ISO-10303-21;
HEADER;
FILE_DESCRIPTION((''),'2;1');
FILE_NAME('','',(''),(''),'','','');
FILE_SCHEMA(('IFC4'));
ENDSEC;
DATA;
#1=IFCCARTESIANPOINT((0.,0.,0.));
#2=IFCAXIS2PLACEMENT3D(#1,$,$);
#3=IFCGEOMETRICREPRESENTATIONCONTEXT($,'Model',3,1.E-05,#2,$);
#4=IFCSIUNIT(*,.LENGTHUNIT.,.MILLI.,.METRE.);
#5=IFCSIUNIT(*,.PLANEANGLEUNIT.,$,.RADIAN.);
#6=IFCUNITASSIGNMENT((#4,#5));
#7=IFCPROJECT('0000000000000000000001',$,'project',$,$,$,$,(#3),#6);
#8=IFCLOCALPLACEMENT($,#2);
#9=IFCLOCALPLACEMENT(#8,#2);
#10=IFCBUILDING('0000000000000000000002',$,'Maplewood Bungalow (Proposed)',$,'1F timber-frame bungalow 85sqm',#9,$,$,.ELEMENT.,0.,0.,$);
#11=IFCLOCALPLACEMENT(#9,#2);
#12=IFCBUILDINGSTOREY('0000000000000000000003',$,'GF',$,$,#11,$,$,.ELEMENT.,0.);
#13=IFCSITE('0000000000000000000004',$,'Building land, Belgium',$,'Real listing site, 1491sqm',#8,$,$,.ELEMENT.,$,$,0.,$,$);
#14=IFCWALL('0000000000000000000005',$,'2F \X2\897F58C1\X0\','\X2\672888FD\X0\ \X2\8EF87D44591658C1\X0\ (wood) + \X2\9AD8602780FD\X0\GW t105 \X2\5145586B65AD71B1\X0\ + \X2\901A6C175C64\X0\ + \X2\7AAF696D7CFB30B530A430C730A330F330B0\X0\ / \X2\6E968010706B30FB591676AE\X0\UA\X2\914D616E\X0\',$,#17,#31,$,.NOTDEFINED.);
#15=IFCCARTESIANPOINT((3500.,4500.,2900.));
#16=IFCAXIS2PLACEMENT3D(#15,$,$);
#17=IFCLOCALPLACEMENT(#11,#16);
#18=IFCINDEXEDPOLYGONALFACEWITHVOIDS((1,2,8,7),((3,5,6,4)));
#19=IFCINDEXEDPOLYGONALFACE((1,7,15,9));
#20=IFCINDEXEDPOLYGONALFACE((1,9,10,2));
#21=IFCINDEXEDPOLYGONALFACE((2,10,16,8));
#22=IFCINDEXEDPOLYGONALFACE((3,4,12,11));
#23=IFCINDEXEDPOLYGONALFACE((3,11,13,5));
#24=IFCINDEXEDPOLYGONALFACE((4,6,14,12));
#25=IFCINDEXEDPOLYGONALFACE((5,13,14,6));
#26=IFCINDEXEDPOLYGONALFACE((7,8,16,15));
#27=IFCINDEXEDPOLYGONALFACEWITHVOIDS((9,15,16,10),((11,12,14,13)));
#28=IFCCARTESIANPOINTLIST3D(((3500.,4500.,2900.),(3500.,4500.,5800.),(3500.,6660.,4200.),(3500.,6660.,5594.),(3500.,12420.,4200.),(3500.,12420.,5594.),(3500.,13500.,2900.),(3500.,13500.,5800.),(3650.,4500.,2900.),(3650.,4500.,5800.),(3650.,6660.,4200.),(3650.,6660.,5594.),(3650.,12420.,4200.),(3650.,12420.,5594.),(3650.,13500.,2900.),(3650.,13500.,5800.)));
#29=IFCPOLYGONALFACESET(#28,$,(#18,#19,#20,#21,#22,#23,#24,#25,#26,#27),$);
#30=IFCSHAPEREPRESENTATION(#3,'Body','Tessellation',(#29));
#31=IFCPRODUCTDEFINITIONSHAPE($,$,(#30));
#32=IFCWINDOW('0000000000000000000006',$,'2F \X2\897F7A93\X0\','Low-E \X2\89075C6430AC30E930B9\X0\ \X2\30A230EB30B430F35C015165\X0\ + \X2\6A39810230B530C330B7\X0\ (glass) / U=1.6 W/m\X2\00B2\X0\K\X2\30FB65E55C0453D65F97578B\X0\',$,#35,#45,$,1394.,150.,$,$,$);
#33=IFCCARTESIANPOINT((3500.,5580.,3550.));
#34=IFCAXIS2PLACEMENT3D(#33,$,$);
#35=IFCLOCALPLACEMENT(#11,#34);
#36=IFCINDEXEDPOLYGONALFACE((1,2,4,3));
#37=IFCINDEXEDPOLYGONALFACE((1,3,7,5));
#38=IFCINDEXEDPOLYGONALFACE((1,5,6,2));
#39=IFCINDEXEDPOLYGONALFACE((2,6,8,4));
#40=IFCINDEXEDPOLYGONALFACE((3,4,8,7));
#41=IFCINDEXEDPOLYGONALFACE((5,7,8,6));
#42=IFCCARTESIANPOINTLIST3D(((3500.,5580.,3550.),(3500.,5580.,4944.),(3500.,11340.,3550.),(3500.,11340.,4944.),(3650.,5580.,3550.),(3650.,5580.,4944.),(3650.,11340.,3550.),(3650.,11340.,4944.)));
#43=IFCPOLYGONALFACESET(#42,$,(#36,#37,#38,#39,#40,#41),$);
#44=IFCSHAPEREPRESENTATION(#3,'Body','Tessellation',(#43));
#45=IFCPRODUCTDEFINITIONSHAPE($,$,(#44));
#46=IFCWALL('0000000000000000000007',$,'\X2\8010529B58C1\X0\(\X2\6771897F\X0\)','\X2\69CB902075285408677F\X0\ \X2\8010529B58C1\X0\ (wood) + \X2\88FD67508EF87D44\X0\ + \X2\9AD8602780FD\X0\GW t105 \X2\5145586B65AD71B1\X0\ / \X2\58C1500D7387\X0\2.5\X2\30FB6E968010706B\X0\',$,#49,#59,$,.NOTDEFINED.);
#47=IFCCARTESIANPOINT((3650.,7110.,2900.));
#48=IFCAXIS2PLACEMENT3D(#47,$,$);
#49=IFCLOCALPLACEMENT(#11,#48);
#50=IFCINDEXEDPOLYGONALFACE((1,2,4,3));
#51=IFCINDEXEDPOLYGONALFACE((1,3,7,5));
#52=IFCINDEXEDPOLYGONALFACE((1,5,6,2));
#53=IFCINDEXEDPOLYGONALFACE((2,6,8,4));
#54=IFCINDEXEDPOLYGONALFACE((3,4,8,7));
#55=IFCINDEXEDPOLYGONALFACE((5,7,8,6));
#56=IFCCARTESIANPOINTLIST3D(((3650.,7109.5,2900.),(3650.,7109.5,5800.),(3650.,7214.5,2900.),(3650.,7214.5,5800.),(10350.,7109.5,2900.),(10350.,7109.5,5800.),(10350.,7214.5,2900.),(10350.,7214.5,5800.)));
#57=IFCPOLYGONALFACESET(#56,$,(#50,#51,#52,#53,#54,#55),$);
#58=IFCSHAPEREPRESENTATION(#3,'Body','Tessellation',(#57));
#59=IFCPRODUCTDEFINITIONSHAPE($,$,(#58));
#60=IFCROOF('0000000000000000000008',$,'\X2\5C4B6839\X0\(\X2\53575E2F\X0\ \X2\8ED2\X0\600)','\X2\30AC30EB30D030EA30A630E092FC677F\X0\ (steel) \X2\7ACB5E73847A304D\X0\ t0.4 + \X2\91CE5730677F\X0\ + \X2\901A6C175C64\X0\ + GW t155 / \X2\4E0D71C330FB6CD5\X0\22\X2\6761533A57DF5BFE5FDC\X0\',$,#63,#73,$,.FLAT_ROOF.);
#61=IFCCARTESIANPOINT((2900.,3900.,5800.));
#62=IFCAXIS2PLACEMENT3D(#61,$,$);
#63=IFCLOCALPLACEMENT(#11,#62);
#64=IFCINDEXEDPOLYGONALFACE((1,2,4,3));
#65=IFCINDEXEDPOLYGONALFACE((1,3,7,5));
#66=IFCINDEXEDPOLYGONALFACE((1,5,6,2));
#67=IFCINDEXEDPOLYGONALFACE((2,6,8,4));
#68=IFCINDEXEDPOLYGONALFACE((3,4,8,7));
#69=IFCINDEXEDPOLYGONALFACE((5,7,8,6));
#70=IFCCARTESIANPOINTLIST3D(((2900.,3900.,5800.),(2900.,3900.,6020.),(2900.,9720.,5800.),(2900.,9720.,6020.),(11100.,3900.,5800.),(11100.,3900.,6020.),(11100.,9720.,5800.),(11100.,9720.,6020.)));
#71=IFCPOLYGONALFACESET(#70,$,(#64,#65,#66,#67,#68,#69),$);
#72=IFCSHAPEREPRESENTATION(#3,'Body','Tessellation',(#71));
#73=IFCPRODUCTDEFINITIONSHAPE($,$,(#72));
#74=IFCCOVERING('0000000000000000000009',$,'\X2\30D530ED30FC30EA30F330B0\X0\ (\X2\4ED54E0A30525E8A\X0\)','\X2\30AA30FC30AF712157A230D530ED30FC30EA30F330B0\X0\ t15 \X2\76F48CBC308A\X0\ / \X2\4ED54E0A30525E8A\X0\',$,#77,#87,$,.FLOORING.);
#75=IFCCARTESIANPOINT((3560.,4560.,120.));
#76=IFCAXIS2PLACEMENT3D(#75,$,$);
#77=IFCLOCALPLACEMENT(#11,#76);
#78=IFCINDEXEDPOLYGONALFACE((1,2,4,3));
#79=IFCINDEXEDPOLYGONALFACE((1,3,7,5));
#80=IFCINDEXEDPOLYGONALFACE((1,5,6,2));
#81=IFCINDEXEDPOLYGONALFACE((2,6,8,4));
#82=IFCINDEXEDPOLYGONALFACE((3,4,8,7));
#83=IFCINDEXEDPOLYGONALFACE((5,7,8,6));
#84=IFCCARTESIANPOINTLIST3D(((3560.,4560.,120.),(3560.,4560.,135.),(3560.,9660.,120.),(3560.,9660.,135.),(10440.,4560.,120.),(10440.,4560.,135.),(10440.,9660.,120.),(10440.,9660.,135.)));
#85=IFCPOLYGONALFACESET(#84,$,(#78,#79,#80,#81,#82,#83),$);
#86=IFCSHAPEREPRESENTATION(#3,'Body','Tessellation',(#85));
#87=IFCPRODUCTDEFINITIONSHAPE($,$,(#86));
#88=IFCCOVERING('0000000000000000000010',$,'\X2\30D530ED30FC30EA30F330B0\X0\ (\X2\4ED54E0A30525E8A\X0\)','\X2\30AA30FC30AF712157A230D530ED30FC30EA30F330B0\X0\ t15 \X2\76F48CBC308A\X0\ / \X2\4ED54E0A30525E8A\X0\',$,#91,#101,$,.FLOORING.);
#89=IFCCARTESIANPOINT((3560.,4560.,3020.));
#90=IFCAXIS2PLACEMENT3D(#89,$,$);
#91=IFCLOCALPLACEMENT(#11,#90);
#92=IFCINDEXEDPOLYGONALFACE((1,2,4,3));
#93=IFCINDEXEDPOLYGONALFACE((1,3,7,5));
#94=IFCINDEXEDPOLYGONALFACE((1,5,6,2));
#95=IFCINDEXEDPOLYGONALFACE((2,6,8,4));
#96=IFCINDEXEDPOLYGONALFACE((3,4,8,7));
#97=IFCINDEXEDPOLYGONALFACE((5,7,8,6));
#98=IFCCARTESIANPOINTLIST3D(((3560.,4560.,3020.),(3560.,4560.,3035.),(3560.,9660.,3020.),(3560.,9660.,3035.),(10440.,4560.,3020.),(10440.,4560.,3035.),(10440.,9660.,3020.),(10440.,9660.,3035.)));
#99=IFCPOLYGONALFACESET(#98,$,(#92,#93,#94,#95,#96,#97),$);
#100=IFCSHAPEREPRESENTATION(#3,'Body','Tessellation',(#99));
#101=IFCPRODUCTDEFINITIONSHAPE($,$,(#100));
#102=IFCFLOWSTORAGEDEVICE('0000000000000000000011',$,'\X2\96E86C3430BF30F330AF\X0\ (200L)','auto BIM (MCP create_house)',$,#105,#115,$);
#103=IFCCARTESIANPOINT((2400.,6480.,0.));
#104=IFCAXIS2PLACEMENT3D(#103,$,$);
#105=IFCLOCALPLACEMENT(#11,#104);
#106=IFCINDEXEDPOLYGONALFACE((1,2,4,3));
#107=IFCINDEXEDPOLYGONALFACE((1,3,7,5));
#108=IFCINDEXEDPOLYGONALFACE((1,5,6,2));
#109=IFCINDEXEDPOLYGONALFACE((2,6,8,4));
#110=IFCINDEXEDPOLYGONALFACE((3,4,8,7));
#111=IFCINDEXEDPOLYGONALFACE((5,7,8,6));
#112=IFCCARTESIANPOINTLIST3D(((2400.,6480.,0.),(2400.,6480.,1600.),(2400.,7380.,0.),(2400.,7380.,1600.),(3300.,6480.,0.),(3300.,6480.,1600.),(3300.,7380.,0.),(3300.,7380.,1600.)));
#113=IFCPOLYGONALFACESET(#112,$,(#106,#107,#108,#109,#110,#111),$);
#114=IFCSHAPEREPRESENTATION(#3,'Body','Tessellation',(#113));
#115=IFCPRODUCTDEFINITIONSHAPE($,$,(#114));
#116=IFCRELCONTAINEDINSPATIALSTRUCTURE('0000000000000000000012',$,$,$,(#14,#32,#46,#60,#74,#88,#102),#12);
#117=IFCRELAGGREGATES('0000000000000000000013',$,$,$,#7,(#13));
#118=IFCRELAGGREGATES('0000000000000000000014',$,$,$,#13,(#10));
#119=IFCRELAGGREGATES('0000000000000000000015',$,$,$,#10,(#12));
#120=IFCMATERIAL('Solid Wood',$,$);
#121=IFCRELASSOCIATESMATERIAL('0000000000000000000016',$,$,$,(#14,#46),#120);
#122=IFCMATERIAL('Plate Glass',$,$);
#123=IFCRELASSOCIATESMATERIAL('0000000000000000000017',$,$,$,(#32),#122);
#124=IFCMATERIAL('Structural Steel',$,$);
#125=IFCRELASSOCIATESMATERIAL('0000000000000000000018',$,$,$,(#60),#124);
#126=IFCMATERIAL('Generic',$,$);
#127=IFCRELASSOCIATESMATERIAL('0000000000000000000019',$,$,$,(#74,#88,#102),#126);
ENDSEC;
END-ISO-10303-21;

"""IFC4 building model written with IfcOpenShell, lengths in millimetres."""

from ifc_helpers import new_model, si_unit, frame, frame_2d, origin, place, context, project, spatial, rectangle, extrude, material, element, fill, save


model = new_model("IFC4")

# Units and contexts
model_context = context("Model", 3, precision=1e-05, world=origin())
ifc_project = project(units=[si_unit("LENGTHUNIT", "METRE", prefix="MILLI"), si_unit("PLANEANGLEUNIT", "RADIAN")], contexts=[model_context])

# Site, building, storey
site_placement = place(None, origin())
site = spatial("IfcSite", under=ifc_project, at=site_placement, Name="Building land, Belgium", ObjectType="Real listing site, 1491sqm", CompositionType="ELEMENT", RefElevation=0.0)
building_placement = place(site_placement, origin())
building = spatial("IfcBuilding", under=site, at=building_placement, Name="Maplewood Bungalow (Proposed)", ObjectType="1F timber-frame bungalow 85sqm", CompositionType="ELEMENT", ElevationOfRefHeight=0.0, ElevationOfTerrain=0.0)
storey_placement = place(building_placement, origin())
storey = spatial("IfcBuildingStorey", under=building, at=storey_placement, Name="GF", CompositionType="ELEMENT", Elevation=0.0)

# Shared definitions
ifc_material_1 = material(Name="Solid Wood")
ifc_material_2 = material(Name="Generic")

# Shared definitions
ifc_material_3 = material(Name="Plate Glass")

# Wall, opening, window
wall_1_placement = place(storey_placement, frame((3500.0, 4500.0, 2900.0)))
wall_1 = element("IfcWall", 1, at=wall_1_placement, inside=storey, material=ifc_material_1, Name="2F 西壁", Description="木製 軸組外壁 (wood) + 高性能GW t105 充填断熱 + 通気層 + 窯業系サイディング / 準耐火・外皮UA配慮", PredefinedType="NOTDEFINED", context=model_context, shape_type="SweptSolid", body=[
    extrude(rectangle(XDim=150.0, YDim=9000.0, at=frame_2d((75.0, 4500.0))), frame((3500.0, 4500.0, 2900.0)), (0.0, 0.0, 1.0), 2900.0),
])
opening_1_placement = place(storey_placement, frame((3500.0, 5580.0, 3550.0)))
opening_1 = element("IfcOpeningElement", 2, at=opening_1_placement, cuts=wall_1, PredefinedType="NOTDEFINED", context=model_context, shape_type="SweptSolid", body=[
    extrude(rectangle(XDim=150.0, YDim=5760.0, at=frame_2d((75.0, 2880.0))), frame((3500.0, 5580.0, 3550.0)), (0.0, 0.0, 1.0), 1394.0),
])
window_1_placement = place(storey_placement, frame((3500.0, 5580.0, 3550.0)))
window_1 = element("IfcWindow", 3, at=window_1_placement, inside=storey, material=ifc_material_3, Name="2F 西窓", Description="Low-E 複層ガラス アルゴン封入 + 樹脂サッシ (glass) / U=1.6 W/m²K・日射取得型", OverallHeight=1394.0, OverallWidth=150.0, context=model_context, shape_type="SweptSolid", body=[
    extrude(rectangle(XDim=150.0, YDim=5760.0, at=frame_2d((75.0, 2880.0))), frame((3500.0, 5580.0, 3550.0)), (0.0, 0.0, 1.0), 1394.0),
])
fill(opening_1, window_1)

# Wall
wall_2_placement = place(storey_placement, frame((3650.0, 7110.0, 2900.0)))
element("IfcWall", 4, at=wall_2_placement, inside=storey, material=ifc_material_1, Name="耐力壁(東西)", Description="構造用合板 耐力壁 (wood) + 製材軸組 + 高性能GW t105 充填断熱 / 壁倍率2.5・準耐火", PredefinedType="NOTDEFINED", context=model_context, shape_type="SweptSolid", body=[
    extrude(rectangle(XDim=6700.0, YDim=105.0, at=frame_2d((3350.0, 52.0))), frame((3650.0, 7110.0, 2900.0)), (0.0, 0.0, 1.0), 2900.0),
])

# Roof
ifc_material_4 = material(Name="Structural Steel")
for number, where, name in (
    (5, (2900.0, 3900.0, 5800.0), "屋根(南帯 軒600)"),
):
    element("IfcRoof", number, at=place(storey_placement, frame(where)), inside=storey, material=ifc_material_4, Name=name, Description="ガルバリウム鋼板 (steel) 立平葺き t0.4 + 野地板 + 通気層 + GW t155 / 不燃・法22条区域対応", PredefinedType="FLAT_ROOF", context=model_context, shape_type="SweptSolid", body=[
        extrude(rectangle(XDim=8200.0, YDim=5820.0, at=frame_2d((4100.0, 2910.0))), frame((2900.0, 3900.0, 5800.0)), (0.0, 0.0, 1.0), 220.0),
    ])

# Coverings
covering_1_placement = place(storey_placement, frame((3560.0, 4560.0, 120.0)))
element("IfcCovering", 6, at=covering_1_placement, inside=storey, material=ifc_material_2, Name="フローリング (仕上げ床)", Description="オーク無垢フローリング t15 直貼り / 仕上げ床", PredefinedType="FLOORING", context=model_context, shape_type="SweptSolid", body=[
    extrude(rectangle(XDim=6880.0, YDim=5100.0, at=frame_2d((3440.0, 2550.0))), frame((3560.0, 4560.0, 120.0)), (0.0, 0.0, 1.0), 15.0),
])
covering_2_placement = place(storey_placement, frame((3560.0, 4560.0, 3020.0)))
element("IfcCovering", 7, at=covering_2_placement, inside=storey, material=ifc_material_2, Name="フローリング (仕上げ床)", Description="オーク無垢フローリング t15 直貼り / 仕上げ床", PredefinedType="FLOORING", context=model_context, shape_type="SweptSolid", body=[
    extrude(rectangle(XDim=6880.0, YDim=5100.0, at=frame_2d((3440.0, 2550.0))), frame((3560.0, 4560.0, 3020.0)), (0.0, 0.0, 1.0), 15.0),
])

# Flow storage device
flow_storage_device_placement = place(storey_placement, frame((2400.0, 6480.0, 0.0)))
element("IfcFlowStorageDevice", 8, at=flow_storage_device_placement, inside=storey, material=ifc_material_2, Name="雨水タンク (200L)", Description="auto BIM (MCP create_house)", context=model_context, shape_type="SweptSolid", body=[
    extrude(rectangle(XDim=900.0, YDim=900.0, at=frame_2d((450.0, 450.0))), frame((2400.0, 6480.0, 0.0)), (0.0, 0.0, 1.0), 1600.0),
])

save(model, "model.ifc")
